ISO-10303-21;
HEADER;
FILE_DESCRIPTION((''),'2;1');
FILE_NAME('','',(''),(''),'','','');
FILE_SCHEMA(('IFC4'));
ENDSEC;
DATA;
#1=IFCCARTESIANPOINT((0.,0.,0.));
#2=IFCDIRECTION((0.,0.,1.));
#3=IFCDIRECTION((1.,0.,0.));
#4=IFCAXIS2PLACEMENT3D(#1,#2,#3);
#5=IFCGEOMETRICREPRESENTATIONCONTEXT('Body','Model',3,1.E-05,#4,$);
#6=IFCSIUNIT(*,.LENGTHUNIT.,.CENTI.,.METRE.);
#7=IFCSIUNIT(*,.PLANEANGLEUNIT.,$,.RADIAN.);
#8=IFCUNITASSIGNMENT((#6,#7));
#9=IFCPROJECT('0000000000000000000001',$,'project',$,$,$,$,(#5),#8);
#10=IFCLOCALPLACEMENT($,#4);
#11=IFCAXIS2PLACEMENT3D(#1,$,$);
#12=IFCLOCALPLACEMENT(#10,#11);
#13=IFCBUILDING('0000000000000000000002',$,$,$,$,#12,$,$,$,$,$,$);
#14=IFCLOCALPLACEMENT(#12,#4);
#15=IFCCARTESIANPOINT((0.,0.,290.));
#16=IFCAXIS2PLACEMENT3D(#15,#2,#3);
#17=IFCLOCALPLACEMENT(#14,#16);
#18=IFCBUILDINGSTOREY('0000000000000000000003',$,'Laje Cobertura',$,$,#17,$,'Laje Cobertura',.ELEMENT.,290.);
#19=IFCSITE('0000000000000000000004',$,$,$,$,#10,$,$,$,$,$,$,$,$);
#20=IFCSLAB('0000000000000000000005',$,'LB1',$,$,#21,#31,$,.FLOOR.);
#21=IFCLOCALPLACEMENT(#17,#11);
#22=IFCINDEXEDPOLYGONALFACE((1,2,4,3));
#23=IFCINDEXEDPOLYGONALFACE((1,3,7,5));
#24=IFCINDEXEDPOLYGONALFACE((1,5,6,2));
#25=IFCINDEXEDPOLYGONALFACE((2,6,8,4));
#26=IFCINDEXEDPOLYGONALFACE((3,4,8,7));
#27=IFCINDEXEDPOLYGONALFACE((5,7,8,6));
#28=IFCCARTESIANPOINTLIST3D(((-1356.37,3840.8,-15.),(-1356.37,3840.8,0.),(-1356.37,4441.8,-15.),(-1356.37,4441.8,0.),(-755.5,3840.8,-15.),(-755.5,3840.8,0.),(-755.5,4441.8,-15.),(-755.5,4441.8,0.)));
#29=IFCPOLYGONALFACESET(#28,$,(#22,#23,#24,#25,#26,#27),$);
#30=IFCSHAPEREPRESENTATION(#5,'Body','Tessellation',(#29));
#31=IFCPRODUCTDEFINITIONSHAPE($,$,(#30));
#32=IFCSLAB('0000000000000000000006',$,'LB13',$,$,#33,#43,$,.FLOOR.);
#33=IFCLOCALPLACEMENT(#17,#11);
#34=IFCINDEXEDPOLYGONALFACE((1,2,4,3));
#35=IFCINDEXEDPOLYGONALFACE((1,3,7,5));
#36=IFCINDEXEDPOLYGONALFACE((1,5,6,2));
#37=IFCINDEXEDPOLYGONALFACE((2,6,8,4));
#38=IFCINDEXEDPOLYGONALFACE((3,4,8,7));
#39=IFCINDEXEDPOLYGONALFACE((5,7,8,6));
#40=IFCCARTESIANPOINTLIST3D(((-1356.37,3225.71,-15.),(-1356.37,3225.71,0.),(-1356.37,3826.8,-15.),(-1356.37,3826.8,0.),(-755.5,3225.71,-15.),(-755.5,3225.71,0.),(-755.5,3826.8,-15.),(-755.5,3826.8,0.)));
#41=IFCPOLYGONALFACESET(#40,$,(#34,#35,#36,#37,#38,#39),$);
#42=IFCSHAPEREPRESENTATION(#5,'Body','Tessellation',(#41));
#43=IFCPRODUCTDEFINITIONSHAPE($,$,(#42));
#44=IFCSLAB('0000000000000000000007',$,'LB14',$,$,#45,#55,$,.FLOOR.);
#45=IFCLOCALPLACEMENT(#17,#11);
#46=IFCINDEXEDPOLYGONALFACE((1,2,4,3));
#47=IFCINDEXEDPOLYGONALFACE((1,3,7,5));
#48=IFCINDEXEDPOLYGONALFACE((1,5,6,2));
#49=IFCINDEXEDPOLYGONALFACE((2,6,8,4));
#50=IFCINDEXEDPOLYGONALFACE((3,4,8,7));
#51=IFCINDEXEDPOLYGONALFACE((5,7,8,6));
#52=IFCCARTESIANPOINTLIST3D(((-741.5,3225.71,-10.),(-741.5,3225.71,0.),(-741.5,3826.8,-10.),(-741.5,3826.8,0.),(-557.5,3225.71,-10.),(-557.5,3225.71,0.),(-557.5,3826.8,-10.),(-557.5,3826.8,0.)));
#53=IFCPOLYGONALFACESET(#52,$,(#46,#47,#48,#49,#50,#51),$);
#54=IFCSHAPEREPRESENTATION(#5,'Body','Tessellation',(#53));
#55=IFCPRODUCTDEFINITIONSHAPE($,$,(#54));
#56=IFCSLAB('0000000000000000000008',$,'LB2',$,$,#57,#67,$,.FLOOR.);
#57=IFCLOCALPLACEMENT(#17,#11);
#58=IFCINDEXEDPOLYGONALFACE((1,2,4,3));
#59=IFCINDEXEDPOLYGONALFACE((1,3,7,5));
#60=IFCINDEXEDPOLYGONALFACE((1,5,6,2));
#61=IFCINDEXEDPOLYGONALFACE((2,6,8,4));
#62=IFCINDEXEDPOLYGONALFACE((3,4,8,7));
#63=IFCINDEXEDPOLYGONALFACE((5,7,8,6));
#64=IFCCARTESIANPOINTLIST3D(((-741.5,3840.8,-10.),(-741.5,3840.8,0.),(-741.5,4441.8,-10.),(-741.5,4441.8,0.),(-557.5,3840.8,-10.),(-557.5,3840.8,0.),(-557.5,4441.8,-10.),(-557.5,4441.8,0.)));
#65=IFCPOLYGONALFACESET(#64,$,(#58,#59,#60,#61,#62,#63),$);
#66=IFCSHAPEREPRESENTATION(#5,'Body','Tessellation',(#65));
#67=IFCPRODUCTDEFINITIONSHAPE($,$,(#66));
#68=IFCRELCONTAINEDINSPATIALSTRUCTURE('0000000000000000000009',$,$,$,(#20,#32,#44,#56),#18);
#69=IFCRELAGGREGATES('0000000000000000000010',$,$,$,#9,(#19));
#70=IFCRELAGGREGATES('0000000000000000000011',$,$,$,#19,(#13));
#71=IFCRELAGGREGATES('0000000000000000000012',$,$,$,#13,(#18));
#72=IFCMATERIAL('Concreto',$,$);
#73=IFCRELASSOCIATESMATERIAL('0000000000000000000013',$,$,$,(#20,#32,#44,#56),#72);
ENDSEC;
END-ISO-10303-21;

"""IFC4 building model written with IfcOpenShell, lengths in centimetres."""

from ifc_helpers import new_model, si_unit, frame, origin, origin_with_axes, place, context, project, spatial, polyline, outline, extrude, material, element, save


model = new_model("IFC4")

# Units and contexts
model_context = context("Model", 3, precision=1e-05, world=origin_with_axes(), identifier="Body")
ifc_project = project(units=[si_unit("LENGTHUNIT", "METRE", prefix="CENTI"), si_unit("PLANEANGLEUNIT", "RADIAN")], contexts=[model_context])

# Site, building, storey
site_placement = place(None, origin_with_axes())
site = spatial("IfcSite", under=ifc_project, at=site_placement)
building_placement = place(site_placement, origin())
building = spatial("IfcBuilding", under=site, at=building_placement)
placement = place(building_placement, origin_with_axes())
storey_placement = place(placement, frame((0.0, 0.0, 290.0), z_axis=(0.0, 0.0, 1.0), x_axis=(1.0, 0.0, 0.0)))
storey = spatial("IfcBuildingStorey", under=building, at=storey_placement, Name="Laje Cobertura", LongName="Laje Cobertura", CompositionType="ELEMENT", Elevation=290.0)

# Shared definitions
ifc_material = material(Name="Concreto")

# Slabs
slab_1_placement = place(storey_placement, frame((-1055.93, 4141.3, 0.0), z_axis=(0.0, 0.0, 1.0), x_axis=(1.0, 0.0, 0.0)))
element("IfcSlab", 1, at=slab_1_placement, inside=storey, material=ifc_material, Name="LB1", PredefinedType="FLOOR", context=model_context, shape_type="SolidModel", body=[
    extrude(outline(polyline([(300.44, 300.5), (-300.43, 300.5), (-300.43, -300.5), (300.44, -300.5), (300.44, 300.5), (300.44, 300.5)])), frame((0.0, 0.0, -15.0), z_axis=(0.0, 0.0, 1.0), x_axis=(1.0, 0.0, 0.0)), (0.0, 0.0, 1.0), 15.0),
])
slab_2_placement = place(storey_placement, frame((-1055.93, 3526.26, 0.0), z_axis=(0.0, 0.0, 1.0), x_axis=(1.0, 0.0, 0.0)))
element("IfcSlab", 2, at=slab_2_placement, inside=storey, material=ifc_material, Name="LB13", PredefinedType="FLOOR", context=model_context, shape_type="SolidModel", body=[
    extrude(outline(polyline([(300.44, 300.55), (-300.43, 300.54), (-300.43, -300.54), (300.44, -300.55), (300.44, 300.55), (300.44, 300.55)])), frame((0.0, 0.0, -15.0), z_axis=(0.0, 0.0, 1.0), x_axis=(1.0, 0.0, 0.0)), (0.0, 0.0, 1.0), 15.0),
])
slab_3_placement = place(storey_placement, frame((-649.5, 3526.26, 0.0), z_axis=(0.0, 0.0, 1.0), x_axis=(1.0, 0.0, 0.0)))
element("IfcSlab", 3, at=slab_3_placement, inside=storey, material=ifc_material, Name="LB14", PredefinedType="FLOOR", context=model_context, shape_type="SolidModel", body=[
    extrude(outline(polyline([(92.0, 300.55), (-92.0, 300.55), (-92.0, -300.54), (92.0, -300.54), (92.0, 300.55), (92.0, 300.55)])), frame((0.0, 0.0, -10.0), z_axis=(0.0, 0.0, 1.0), x_axis=(1.0, 0.0, 0.0)), (0.0, 0.0, 1.0), 10.0),
])
slab_4_placement = place(storey_placement, frame((-649.5, 4141.3, 0.0), z_axis=(0.0, 0.0, 1.0), x_axis=(1.0, 0.0, 0.0)))
element("IfcSlab", 4, at=slab_4_placement, inside=storey, material=ifc_material, Name="LB2", PredefinedType="FLOOR", context=model_context, shape_type="SolidModel", body=[
    extrude(outline(polyline([(92.0, 300.5), (-92.0, 300.5), (-92.0, -300.5), (92.0, -300.5), (92.0, 300.5), (92.0, 300.5)])), frame((0.0, 0.0, -10.0), z_axis=(0.0, 0.0, 1.0), x_axis=(1.0, 0.0, 0.0)), (0.0, 0.0, 1.0), 10.0),
])

save(model, "model.ifc")
